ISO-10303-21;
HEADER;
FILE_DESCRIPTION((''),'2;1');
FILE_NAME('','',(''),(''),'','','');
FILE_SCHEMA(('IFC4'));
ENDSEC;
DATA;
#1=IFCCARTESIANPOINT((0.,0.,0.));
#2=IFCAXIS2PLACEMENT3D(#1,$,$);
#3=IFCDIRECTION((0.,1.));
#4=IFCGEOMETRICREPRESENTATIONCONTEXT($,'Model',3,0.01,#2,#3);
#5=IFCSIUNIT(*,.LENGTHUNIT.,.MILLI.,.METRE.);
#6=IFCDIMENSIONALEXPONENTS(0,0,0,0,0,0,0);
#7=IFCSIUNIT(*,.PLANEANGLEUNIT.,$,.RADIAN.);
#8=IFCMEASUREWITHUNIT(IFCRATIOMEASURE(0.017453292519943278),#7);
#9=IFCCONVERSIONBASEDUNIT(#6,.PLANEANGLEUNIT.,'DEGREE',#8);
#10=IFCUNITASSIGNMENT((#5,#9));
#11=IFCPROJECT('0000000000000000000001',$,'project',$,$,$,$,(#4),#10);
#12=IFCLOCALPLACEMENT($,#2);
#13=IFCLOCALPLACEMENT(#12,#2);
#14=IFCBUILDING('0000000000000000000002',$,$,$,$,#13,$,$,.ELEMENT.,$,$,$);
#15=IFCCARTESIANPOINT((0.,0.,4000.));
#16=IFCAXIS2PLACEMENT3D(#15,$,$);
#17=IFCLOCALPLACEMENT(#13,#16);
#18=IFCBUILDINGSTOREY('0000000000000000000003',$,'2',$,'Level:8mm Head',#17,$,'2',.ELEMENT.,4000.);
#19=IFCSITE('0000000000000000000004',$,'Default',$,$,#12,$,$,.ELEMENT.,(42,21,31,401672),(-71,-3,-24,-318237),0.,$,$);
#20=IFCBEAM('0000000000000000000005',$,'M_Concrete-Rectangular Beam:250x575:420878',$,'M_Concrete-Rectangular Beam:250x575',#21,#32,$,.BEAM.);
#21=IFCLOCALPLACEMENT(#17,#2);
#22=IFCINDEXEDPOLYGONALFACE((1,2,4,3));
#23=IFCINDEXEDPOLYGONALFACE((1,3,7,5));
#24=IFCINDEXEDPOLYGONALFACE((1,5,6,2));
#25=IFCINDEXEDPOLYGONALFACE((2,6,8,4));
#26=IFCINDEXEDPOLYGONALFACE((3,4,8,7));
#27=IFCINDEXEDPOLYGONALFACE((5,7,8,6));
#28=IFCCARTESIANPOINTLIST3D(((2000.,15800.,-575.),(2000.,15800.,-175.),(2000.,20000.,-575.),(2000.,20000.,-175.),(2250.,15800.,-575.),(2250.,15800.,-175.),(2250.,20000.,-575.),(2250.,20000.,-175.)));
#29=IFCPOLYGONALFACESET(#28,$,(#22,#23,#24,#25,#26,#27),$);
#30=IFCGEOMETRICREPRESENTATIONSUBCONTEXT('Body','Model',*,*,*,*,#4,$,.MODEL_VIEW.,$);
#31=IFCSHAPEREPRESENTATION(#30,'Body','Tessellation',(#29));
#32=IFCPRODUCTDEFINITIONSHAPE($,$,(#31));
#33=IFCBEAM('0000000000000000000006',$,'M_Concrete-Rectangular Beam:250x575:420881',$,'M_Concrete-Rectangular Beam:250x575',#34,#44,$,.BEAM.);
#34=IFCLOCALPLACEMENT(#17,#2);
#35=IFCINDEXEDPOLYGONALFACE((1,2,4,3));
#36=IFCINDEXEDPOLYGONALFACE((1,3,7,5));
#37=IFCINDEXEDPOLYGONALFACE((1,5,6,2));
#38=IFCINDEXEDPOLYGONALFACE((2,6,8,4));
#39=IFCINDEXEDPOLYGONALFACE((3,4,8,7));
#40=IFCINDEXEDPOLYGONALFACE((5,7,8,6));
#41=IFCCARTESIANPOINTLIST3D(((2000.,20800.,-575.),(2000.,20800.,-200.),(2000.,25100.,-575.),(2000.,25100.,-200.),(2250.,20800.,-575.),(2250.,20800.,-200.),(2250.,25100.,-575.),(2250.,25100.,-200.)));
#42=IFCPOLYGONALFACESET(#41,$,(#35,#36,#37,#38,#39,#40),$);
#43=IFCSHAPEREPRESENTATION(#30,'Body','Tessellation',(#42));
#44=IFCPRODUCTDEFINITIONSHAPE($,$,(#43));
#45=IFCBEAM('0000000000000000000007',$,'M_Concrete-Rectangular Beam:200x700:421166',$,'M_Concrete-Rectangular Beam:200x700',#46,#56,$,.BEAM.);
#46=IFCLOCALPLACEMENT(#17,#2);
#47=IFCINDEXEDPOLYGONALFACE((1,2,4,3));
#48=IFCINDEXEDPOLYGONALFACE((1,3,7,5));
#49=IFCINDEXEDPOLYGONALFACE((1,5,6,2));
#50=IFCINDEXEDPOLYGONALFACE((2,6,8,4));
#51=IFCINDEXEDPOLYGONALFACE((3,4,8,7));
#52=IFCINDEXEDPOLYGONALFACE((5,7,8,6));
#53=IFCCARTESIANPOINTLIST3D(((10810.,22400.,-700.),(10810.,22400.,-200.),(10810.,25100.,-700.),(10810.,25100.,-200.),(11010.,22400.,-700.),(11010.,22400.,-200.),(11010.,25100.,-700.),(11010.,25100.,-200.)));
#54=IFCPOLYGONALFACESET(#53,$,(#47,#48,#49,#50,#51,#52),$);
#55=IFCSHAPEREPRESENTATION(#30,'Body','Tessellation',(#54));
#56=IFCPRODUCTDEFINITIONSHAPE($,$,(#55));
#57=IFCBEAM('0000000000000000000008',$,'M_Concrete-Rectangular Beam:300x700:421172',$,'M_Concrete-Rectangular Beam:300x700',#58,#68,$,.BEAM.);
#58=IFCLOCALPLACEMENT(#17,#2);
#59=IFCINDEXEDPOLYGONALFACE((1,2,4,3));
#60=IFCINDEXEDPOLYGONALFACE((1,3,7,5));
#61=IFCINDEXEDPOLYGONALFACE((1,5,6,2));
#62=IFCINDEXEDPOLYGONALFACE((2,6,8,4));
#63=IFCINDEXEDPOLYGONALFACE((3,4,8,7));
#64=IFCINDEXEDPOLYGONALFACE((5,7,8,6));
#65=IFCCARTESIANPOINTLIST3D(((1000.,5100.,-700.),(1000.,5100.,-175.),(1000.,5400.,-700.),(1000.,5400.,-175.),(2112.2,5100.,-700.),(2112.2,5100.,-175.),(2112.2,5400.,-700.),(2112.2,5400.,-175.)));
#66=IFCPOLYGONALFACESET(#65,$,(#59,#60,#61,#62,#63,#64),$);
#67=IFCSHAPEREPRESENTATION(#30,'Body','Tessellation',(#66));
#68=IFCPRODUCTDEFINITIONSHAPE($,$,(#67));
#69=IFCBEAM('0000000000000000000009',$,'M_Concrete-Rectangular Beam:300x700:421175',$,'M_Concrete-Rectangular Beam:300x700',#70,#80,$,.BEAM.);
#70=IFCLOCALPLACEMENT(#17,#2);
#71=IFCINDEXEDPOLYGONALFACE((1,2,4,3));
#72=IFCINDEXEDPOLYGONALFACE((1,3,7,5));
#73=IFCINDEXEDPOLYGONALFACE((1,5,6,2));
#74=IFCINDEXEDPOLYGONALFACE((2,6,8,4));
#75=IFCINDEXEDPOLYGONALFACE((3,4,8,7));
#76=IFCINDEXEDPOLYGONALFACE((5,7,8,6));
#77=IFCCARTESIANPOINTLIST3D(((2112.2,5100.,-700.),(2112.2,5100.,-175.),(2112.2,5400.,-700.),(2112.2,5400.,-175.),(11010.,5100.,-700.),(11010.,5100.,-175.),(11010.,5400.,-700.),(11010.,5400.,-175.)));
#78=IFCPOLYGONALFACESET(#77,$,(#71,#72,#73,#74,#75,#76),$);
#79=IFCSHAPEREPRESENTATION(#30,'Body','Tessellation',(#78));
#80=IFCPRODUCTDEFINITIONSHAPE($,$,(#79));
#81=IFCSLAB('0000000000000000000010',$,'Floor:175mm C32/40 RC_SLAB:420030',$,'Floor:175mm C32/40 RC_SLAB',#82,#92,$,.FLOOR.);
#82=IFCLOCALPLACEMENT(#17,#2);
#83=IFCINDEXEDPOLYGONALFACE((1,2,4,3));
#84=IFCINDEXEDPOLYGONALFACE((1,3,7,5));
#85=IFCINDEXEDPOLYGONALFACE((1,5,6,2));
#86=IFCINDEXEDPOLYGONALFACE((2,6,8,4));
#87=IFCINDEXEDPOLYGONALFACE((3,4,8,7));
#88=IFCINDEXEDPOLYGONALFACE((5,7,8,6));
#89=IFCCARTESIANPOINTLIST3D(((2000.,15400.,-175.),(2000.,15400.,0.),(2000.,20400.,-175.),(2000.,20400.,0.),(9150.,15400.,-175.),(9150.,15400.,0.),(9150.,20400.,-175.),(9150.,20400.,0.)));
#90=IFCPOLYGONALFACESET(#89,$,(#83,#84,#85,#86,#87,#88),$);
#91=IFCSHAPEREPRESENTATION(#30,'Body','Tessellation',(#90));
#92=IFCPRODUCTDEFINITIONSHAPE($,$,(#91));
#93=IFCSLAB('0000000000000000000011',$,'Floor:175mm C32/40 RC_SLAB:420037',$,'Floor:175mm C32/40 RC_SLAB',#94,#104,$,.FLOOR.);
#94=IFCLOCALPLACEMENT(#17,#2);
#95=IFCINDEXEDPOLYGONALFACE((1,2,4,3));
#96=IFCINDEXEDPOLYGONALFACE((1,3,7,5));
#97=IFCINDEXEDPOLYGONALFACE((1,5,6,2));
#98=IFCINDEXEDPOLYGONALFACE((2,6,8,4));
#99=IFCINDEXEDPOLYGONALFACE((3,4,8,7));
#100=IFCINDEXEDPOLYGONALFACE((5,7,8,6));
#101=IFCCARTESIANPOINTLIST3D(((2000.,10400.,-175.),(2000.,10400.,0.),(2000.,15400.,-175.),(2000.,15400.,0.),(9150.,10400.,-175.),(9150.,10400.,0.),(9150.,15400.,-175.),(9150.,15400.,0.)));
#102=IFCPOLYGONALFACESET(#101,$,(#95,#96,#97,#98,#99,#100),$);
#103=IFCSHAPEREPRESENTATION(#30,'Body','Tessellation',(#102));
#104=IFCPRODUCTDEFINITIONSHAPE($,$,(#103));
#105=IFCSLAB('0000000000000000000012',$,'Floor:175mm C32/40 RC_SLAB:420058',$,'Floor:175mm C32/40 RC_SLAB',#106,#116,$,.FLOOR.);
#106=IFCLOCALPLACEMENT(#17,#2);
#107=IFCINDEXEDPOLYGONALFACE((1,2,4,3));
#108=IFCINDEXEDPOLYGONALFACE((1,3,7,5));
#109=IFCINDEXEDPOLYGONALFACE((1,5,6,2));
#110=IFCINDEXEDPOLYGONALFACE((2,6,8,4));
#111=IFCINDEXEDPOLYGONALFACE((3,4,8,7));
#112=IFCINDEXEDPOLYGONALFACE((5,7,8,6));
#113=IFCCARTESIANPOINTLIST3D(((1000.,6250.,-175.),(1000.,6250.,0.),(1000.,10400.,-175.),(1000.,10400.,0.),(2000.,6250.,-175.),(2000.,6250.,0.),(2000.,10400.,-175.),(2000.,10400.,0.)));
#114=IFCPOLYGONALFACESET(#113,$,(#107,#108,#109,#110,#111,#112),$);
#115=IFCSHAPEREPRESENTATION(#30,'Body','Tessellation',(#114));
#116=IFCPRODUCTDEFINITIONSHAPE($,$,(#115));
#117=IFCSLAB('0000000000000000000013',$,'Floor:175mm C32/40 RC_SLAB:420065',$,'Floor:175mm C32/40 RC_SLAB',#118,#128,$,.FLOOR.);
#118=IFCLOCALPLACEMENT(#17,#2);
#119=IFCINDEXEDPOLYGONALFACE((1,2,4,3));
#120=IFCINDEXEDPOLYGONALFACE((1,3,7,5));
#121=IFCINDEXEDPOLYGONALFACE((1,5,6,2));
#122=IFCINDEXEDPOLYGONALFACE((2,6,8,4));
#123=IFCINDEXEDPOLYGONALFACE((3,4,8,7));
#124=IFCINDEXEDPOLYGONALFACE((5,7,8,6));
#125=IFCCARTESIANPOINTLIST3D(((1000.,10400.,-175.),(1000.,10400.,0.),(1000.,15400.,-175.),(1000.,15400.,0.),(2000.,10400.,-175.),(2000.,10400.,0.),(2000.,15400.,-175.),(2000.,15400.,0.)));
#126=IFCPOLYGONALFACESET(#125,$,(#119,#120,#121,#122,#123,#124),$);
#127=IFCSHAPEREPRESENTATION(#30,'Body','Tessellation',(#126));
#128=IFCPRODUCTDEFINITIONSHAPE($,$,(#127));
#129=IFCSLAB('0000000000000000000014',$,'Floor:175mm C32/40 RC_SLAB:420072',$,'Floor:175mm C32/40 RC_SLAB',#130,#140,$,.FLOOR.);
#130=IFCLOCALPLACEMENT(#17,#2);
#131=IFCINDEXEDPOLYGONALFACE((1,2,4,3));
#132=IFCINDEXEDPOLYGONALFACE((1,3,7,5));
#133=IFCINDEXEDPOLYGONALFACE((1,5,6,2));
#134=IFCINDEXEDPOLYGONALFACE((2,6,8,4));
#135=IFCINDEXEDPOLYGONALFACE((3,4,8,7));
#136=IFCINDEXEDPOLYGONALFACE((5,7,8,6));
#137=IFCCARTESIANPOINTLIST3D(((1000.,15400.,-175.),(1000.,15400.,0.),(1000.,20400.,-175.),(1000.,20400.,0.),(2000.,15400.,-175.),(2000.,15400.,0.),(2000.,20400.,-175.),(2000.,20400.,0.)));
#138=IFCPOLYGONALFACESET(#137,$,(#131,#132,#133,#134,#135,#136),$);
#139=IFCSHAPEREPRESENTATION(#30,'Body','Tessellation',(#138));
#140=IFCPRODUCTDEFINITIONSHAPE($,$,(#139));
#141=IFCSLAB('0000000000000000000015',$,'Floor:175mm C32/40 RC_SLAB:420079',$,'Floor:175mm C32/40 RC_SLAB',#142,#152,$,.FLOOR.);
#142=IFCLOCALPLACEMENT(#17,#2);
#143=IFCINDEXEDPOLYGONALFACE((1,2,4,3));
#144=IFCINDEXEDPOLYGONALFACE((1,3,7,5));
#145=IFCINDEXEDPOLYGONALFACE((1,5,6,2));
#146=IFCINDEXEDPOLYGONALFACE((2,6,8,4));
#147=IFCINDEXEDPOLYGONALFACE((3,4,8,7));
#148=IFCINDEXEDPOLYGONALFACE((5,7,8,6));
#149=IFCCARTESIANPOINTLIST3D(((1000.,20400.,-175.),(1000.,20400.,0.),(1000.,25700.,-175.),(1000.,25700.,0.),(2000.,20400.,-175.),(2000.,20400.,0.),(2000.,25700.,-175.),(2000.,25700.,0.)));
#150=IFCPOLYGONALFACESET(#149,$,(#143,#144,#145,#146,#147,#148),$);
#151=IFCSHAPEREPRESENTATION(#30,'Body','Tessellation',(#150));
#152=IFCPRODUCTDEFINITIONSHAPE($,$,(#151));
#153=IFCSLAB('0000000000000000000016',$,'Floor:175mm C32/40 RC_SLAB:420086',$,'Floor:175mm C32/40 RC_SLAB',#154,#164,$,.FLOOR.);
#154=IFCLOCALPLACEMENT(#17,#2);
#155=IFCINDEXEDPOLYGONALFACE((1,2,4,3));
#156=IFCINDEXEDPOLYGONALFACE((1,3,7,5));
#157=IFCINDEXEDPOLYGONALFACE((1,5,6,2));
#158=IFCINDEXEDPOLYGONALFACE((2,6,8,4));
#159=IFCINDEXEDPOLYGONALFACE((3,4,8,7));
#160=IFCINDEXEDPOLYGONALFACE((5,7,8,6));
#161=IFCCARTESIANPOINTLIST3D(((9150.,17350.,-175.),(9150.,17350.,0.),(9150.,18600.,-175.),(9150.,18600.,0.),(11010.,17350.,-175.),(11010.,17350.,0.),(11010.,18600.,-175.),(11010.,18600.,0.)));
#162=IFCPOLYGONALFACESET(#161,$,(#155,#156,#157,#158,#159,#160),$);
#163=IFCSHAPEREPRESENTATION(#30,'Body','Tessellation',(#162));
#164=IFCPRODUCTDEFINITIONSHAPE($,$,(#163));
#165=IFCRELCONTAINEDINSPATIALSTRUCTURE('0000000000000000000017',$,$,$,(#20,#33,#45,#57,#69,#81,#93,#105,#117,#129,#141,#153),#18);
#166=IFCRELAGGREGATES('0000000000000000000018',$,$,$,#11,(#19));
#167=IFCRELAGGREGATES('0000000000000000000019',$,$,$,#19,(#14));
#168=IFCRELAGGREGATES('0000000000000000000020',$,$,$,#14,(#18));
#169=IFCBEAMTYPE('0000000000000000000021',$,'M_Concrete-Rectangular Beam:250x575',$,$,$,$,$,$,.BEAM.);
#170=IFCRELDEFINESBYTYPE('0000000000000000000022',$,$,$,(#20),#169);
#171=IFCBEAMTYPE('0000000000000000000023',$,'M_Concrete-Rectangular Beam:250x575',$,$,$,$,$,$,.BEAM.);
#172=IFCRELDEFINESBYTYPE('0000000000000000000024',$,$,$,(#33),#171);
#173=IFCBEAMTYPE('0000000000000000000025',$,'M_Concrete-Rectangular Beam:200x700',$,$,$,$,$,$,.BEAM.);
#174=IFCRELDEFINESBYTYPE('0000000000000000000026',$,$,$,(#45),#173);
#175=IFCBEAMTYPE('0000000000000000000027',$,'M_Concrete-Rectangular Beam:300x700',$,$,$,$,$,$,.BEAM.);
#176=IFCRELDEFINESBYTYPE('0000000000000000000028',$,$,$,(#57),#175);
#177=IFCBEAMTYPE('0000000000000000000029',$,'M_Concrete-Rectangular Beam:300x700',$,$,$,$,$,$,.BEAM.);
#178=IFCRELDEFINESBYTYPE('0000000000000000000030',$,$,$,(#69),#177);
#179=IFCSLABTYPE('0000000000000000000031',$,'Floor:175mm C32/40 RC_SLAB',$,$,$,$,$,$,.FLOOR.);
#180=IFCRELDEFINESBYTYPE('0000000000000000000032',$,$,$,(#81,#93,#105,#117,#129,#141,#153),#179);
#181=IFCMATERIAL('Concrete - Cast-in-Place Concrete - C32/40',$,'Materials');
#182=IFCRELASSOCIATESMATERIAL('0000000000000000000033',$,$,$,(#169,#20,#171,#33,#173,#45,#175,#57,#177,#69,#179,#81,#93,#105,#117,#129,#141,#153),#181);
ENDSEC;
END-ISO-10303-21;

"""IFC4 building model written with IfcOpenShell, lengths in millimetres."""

from ifc_helpers import new_model, entity, si_unit, converted_unit, direction, frame, origin, place, context, subcontext, project, spatial, indexed_curve, outline, extrude, source, transform, mapped, material, type_object, type_shapes, element, save


model = new_model("IFC4")

# Units and contexts
model_context = context("Model", 3, precision=0.01, world=origin(), true_north=direction((0.0, 1.0)))
body_context = subcontext(model_context, "Body", "Model", "MODEL_VIEW")
ifc_project = project(units=[si_unit("LENGTHUNIT", "METRE", prefix="MILLI"), converted_unit("PLANEANGLEUNIT", "DEGREE", entity("IfcRatioMeasure", 0.017453292519943278), si_unit("PLANEANGLEUNIT", "RADIAN"), dimensions=[0, 0, 0, 0, 0, 0, 0])], contexts=[model_context])

# Site, building, storey
site_placement = place(None, origin())
site = spatial("IfcSite", under=ifc_project, at=site_placement, Name="Default", CompositionType="ELEMENT", RefLatitude=(42, 21, 31, 401672), RefLongitude=(-71, -3, -24, -318237), RefElevation=0.0)
building_placement = place(site_placement, origin())
building = spatial("IfcBuilding", under=site, at=building_placement, CompositionType="ELEMENT")
storey_placement = place(building_placement, frame((0.0, 0.0, 4000.0)))
storey = spatial("IfcBuildingStorey", under=building, at=storey_placement, Name="2", ObjectType="Level:8mm Head", LongName="2", CompositionType="ELEMENT", Elevation=4000.0)

# Shared definitions
ifc_material = material(Name="Concrete - Cast-in-Place Concrete - C32/40", Category="Materials")

# Beams
beam_type_1 = type_object("IfcBeamType", Name="M_Concrete-Rectangular Beam:250x575", PredefinedType="BEAM", material=ifc_material)
shared_shape_1 = source(origin(), body_context, "Body", "SweptSolid", [
    extrude(outline(indexed_curve([(-125.0, -200.0), (125.0, -200.0), (125.0, 200.0), (-125.0, 200.0), (-125.0, -200.0)], self_intersect=False)), frame((2125.0, 15800.0, 3625.0), z_axis=(0.0, 1.0, 0.0), x_axis=(-1.0, 0.0, 0.0)), (0.0, 0.0, 1.0), 4200.0),
])
type_shapes(beam_type_1, [shared_shape_1])
beam_1_placement = place(storey_placement, frame((0.0, 0.0, -4000.0)))
element("IfcBeam", 1, at=beam_1_placement, inside=storey, type_object=beam_type_1, material=ifc_material, Name="M_Concrete-Rectangular Beam:250x575:420878", ObjectType="M_Concrete-Rectangular Beam:250x575", PredefinedType="BEAM", context=body_context, shape_type="MappedRepresentation", body=[
    mapped(shared_shape_1, transform((0.0, 0.0, 0.0), scale=1.0)),
])
beam_type_2 = type_object("IfcBeamType", Name="M_Concrete-Rectangular Beam:250x575", PredefinedType="BEAM", material=ifc_material)
shared_shape_2 = source(origin(), body_context, "Body", "SweptSolid", [
    extrude(outline(indexed_curve([(-125.0, -187.5), (125.0, -187.5), (125.0, 187.5), (-125.0, 187.5), (-125.0, -187.5)], self_intersect=False)), frame((2125.0, 20800.0, 3612.5), z_axis=(0.0, 1.0, 0.0), x_axis=(-1.0, 0.0, 0.0)), (0.0, 0.0, 1.0), 4300.0),
])
type_shapes(beam_type_2, [shared_shape_2])
beam_2_placement = place(storey_placement, frame((0.0, 0.0, -4000.0)))
element("IfcBeam", 2, at=beam_2_placement, inside=storey, type_object=beam_type_2, material=ifc_material, Name="M_Concrete-Rectangular Beam:250x575:420881", ObjectType="M_Concrete-Rectangular Beam:250x575", PredefinedType="BEAM", context=body_context, shape_type="MappedRepresentation", body=[
    mapped(shared_shape_2, transform((0.0, 0.0, 0.0), scale=1.0)),
])
beam_type_3 = type_object("IfcBeamType", Name="M_Concrete-Rectangular Beam:200x700", PredefinedType="BEAM", material=ifc_material)
shared_shape_3 = source(origin(), body_context, "Body", "SweptSolid", [
    extrude(outline(indexed_curve([(-100.0, -250.0), (100.0, -250.0), (100.0, 250.0), (-100.0, 250.0), (-100.0, -250.0)], self_intersect=False)), frame((10910.0, 22400.0, 3550.0), z_axis=(0.0, 1.0, 0.0), x_axis=(-1.0, 0.0, 0.0)), (0.0, 0.0, 1.0), 2700.0),
])
type_shapes(beam_type_3, [shared_shape_3])
beam_3_placement = place(storey_placement, frame((0.0, 0.0, -4000.0)))
element("IfcBeam", 3, at=beam_3_placement, inside=storey, type_object=beam_type_3, material=ifc_material, Name="M_Concrete-Rectangular Beam:200x700:421166", ObjectType="M_Concrete-Rectangular Beam:200x700", PredefinedType="BEAM", context=body_context, shape_type="MappedRepresentation", body=[
    mapped(shared_shape_3, transform((0.0, 0.0, 0.0), scale=1.0)),
])
beam_type_4 = type_object("IfcBeamType", Name="M_Concrete-Rectangular Beam:300x700", PredefinedType="BEAM", material=ifc_material)
shared_shape_4 = source(origin(), body_context, "Body", "SweptSolid", [
    extrude(outline(indexed_curve([(-262.5, -150.0), (262.5, -150.0), (262.5, 150.0), (-262.5, 150.0), (-262.5, -150.0)], self_intersect=False)), frame((1000.0, 5250.0, 3562.5), z_axis=(1.0, 0.0, 0.0), x_axis=(0.0, 0.0, -1.0)), (0.0, 0.0, 1.0), 1112.2),
])
type_shapes(beam_type_4, [shared_shape_4])
beam_4_placement = place(storey_placement, frame((0.0, 0.0, -4000.0)))
element("IfcBeam", 4, at=beam_4_placement, inside=storey, type_object=beam_type_4, material=ifc_material, Name="M_Concrete-Rectangular Beam:300x700:421172", ObjectType="M_Concrete-Rectangular Beam:300x700", PredefinedType="BEAM", context=body_context, shape_type="MappedRepresentation", body=[
    mapped(shared_shape_4, transform((0.0, 0.0, 0.0), scale=1.0)),
])
beam_type_5 = type_object("IfcBeamType", Name="M_Concrete-Rectangular Beam:300x700", PredefinedType="BEAM", material=ifc_material)
shared_shape_5 = source(origin(), body_context, "Body", "SweptSolid", [
    extrude(outline(indexed_curve([(-262.5, -150.0), (262.5, -150.0), (262.5, 150.0), (-262.5, 150.0), (-262.5, -150.0)], self_intersect=False)), frame((2112.2, 5250.0, 3562.5), z_axis=(1.0, 0.0, 0.0), x_axis=(0.0, 0.0, -1.0)), (0.0, 0.0, 1.0), 8897.8),
])
type_shapes(beam_type_5, [shared_shape_5])
beam_5_placement = place(storey_placement, frame((0.0, 0.0, -4000.0)))
element("IfcBeam", 5, at=beam_5_placement, inside=storey, type_object=beam_type_5, material=ifc_material, Name="M_Concrete-Rectangular Beam:300x700:421175", ObjectType="M_Concrete-Rectangular Beam:300x700", PredefinedType="BEAM", context=body_context, shape_type="MappedRepresentation", body=[
    mapped(shared_shape_5, transform((0.0, 0.0, 0.0), scale=1.0)),
])

# Slabs
slab_type_1 = type_object("IfcSlabType", Name="Floor:175mm C32/40 RC_SLAB", PredefinedType="FLOOR", material=ifc_material)
slab_1_placement = place(storey_placement, origin())
element("IfcSlab", 6, at=slab_1_placement, inside=storey, type_object=slab_type_1, material=ifc_material, Name="Floor:175mm C32/40 RC_SLAB:420030", ObjectType="Floor:175mm C32/40 RC_SLAB", PredefinedType="FLOOR", context=body_context, shape_type="SweptSolid", body=[
    extrude(outline(indexed_curve([(-2500.0, -3575.0), (2500.0, -3575.0), (2500.0, 3575.0), (-2500.0, 3575.0), (-2500.0, -3575.0)], self_intersect=False)), frame((5575.0, 17900.0, 0.0), z_axis=(0.0, 0.0, -1.0), x_axis=(0.0, 1.0, 0.0)), (0.0, 0.0, 1.0), 175.0),
])
slab_2_placement = place(storey_placement, origin())
element("IfcSlab", 7, at=slab_2_placement, inside=storey, type_object=slab_type_1, material=ifc_material, Name="Floor:175mm C32/40 RC_SLAB:420037", ObjectType="Floor:175mm C32/40 RC_SLAB", PredefinedType="FLOOR", context=body_context, shape_type="SweptSolid", body=[
    extrude(outline(indexed_curve([(-2500.0, -3575.0), (2500.0, -3575.0), (2500.0, 3575.0), (-2500.0, 3575.0), (-2500.0, -3575.0)], self_intersect=False)), frame((5575.0, 12900.0, 0.0), z_axis=(0.0, 0.0, -1.0), x_axis=(0.0, 1.0, 0.0)), (0.0, 0.0, 1.0), 175.0),
])
slab_3_placement = place(storey_placement, origin())
element("IfcSlab", 8, at=slab_3_placement, inside=storey, type_object=slab_type_1, material=ifc_material, Name="Floor:175mm C32/40 RC_SLAB:420058", ObjectType="Floor:175mm C32/40 RC_SLAB", PredefinedType="FLOOR", context=body_context, shape_type="SweptSolid", body=[
    extrude(outline(indexed_curve([(-2075.0, -500.0), (2075.0, -500.0), (2075.0, 500.0), (-2075.0, 500.0), (-2075.0, -500.0)], self_intersect=False)), frame((1500.0, 8325.0, 0.0), z_axis=(0.0, 0.0, -1.0), x_axis=(0.0, 1.0, 0.0)), (0.0, 0.0, 1.0), 175.0),
])
slab_4_placement = place(storey_placement, origin())
element("IfcSlab", 9, at=slab_4_placement, inside=storey, type_object=slab_type_1, material=ifc_material, Name="Floor:175mm C32/40 RC_SLAB:420065", ObjectType="Floor:175mm C32/40 RC_SLAB", PredefinedType="FLOOR", context=body_context, shape_type="SweptSolid", body=[
    extrude(outline(indexed_curve([(-2500.0, -500.0), (2500.0, -500.0), (2500.0, 500.0), (-2500.0, 500.0), (-2500.0, -500.0)], self_intersect=False)), frame((1500.0, 12900.0, 0.0), z_axis=(0.0, 0.0, -1.0), x_axis=(0.0, 1.0, 0.0)), (0.0, 0.0, 1.0), 175.0),
])
slab_5_placement = place(storey_placement, origin())
element("IfcSlab", 10, at=slab_5_placement, inside=storey, type_object=slab_type_1, material=ifc_material, Name="Floor:175mm C32/40 RC_SLAB:420072", ObjectType="Floor:175mm C32/40 RC_SLAB", PredefinedType="FLOOR", context=body_context, shape_type="SweptSolid", body=[
    extrude(outline(indexed_curve([(-2500.0, -500.0), (2500.0, -500.0), (2500.0, 500.0), (-2500.0, 500.0), (-2500.0, -500.0)], self_intersect=False)), frame((1500.0, 17900.0, 0.0), z_axis=(0.0, 0.0, -1.0), x_axis=(0.0, 1.0, 0.0)), (0.0, 0.0, 1.0), 175.0),
])
slab_6_placement = place(storey_placement, origin())
element("IfcSlab", 11, at=slab_6_placement, inside=storey, type_object=slab_type_1, material=ifc_material, Name="Floor:175mm C32/40 RC_SLAB:420079", ObjectType="Floor:175mm C32/40 RC_SLAB", PredefinedType="FLOOR", context=body_context, shape_type="SweptSolid", body=[
    extrude(outline(indexed_curve([(-2650.0, -500.0), (2650.0, -500.0), (2650.0, 500.0), (-2650.0, 500.0), (-2650.0, -500.0)], self_intersect=False)), frame((1500.0, 23050.0, 0.0), z_axis=(0.0, 0.0, -1.0), x_axis=(0.0, 1.0, 0.0)), (0.0, 0.0, 1.0), 175.0),
])
slab_7_placement = place(storey_placement, origin())
element("IfcSlab", 12, at=slab_7_placement, inside=storey, type_object=slab_type_1, material=ifc_material, Name="Floor:175mm C32/40 RC_SLAB:420086", ObjectType="Floor:175mm C32/40 RC_SLAB", PredefinedType="FLOOR", context=body_context, shape_type="SweptSolid", body=[
    extrude(outline(indexed_curve([(-625.0, -930.0), (625.0, -930.0), (625.0, 930.0), (-625.0, 930.0), (-625.0, -930.0)], self_intersect=False)), frame((10080.0, 17975.0, 0.0), z_axis=(0.0, 0.0, -1.0), x_axis=(0.0, 1.0, 0.0)), (0.0, 0.0, 1.0), 175.0),
])

save(model, "model.ifc")
